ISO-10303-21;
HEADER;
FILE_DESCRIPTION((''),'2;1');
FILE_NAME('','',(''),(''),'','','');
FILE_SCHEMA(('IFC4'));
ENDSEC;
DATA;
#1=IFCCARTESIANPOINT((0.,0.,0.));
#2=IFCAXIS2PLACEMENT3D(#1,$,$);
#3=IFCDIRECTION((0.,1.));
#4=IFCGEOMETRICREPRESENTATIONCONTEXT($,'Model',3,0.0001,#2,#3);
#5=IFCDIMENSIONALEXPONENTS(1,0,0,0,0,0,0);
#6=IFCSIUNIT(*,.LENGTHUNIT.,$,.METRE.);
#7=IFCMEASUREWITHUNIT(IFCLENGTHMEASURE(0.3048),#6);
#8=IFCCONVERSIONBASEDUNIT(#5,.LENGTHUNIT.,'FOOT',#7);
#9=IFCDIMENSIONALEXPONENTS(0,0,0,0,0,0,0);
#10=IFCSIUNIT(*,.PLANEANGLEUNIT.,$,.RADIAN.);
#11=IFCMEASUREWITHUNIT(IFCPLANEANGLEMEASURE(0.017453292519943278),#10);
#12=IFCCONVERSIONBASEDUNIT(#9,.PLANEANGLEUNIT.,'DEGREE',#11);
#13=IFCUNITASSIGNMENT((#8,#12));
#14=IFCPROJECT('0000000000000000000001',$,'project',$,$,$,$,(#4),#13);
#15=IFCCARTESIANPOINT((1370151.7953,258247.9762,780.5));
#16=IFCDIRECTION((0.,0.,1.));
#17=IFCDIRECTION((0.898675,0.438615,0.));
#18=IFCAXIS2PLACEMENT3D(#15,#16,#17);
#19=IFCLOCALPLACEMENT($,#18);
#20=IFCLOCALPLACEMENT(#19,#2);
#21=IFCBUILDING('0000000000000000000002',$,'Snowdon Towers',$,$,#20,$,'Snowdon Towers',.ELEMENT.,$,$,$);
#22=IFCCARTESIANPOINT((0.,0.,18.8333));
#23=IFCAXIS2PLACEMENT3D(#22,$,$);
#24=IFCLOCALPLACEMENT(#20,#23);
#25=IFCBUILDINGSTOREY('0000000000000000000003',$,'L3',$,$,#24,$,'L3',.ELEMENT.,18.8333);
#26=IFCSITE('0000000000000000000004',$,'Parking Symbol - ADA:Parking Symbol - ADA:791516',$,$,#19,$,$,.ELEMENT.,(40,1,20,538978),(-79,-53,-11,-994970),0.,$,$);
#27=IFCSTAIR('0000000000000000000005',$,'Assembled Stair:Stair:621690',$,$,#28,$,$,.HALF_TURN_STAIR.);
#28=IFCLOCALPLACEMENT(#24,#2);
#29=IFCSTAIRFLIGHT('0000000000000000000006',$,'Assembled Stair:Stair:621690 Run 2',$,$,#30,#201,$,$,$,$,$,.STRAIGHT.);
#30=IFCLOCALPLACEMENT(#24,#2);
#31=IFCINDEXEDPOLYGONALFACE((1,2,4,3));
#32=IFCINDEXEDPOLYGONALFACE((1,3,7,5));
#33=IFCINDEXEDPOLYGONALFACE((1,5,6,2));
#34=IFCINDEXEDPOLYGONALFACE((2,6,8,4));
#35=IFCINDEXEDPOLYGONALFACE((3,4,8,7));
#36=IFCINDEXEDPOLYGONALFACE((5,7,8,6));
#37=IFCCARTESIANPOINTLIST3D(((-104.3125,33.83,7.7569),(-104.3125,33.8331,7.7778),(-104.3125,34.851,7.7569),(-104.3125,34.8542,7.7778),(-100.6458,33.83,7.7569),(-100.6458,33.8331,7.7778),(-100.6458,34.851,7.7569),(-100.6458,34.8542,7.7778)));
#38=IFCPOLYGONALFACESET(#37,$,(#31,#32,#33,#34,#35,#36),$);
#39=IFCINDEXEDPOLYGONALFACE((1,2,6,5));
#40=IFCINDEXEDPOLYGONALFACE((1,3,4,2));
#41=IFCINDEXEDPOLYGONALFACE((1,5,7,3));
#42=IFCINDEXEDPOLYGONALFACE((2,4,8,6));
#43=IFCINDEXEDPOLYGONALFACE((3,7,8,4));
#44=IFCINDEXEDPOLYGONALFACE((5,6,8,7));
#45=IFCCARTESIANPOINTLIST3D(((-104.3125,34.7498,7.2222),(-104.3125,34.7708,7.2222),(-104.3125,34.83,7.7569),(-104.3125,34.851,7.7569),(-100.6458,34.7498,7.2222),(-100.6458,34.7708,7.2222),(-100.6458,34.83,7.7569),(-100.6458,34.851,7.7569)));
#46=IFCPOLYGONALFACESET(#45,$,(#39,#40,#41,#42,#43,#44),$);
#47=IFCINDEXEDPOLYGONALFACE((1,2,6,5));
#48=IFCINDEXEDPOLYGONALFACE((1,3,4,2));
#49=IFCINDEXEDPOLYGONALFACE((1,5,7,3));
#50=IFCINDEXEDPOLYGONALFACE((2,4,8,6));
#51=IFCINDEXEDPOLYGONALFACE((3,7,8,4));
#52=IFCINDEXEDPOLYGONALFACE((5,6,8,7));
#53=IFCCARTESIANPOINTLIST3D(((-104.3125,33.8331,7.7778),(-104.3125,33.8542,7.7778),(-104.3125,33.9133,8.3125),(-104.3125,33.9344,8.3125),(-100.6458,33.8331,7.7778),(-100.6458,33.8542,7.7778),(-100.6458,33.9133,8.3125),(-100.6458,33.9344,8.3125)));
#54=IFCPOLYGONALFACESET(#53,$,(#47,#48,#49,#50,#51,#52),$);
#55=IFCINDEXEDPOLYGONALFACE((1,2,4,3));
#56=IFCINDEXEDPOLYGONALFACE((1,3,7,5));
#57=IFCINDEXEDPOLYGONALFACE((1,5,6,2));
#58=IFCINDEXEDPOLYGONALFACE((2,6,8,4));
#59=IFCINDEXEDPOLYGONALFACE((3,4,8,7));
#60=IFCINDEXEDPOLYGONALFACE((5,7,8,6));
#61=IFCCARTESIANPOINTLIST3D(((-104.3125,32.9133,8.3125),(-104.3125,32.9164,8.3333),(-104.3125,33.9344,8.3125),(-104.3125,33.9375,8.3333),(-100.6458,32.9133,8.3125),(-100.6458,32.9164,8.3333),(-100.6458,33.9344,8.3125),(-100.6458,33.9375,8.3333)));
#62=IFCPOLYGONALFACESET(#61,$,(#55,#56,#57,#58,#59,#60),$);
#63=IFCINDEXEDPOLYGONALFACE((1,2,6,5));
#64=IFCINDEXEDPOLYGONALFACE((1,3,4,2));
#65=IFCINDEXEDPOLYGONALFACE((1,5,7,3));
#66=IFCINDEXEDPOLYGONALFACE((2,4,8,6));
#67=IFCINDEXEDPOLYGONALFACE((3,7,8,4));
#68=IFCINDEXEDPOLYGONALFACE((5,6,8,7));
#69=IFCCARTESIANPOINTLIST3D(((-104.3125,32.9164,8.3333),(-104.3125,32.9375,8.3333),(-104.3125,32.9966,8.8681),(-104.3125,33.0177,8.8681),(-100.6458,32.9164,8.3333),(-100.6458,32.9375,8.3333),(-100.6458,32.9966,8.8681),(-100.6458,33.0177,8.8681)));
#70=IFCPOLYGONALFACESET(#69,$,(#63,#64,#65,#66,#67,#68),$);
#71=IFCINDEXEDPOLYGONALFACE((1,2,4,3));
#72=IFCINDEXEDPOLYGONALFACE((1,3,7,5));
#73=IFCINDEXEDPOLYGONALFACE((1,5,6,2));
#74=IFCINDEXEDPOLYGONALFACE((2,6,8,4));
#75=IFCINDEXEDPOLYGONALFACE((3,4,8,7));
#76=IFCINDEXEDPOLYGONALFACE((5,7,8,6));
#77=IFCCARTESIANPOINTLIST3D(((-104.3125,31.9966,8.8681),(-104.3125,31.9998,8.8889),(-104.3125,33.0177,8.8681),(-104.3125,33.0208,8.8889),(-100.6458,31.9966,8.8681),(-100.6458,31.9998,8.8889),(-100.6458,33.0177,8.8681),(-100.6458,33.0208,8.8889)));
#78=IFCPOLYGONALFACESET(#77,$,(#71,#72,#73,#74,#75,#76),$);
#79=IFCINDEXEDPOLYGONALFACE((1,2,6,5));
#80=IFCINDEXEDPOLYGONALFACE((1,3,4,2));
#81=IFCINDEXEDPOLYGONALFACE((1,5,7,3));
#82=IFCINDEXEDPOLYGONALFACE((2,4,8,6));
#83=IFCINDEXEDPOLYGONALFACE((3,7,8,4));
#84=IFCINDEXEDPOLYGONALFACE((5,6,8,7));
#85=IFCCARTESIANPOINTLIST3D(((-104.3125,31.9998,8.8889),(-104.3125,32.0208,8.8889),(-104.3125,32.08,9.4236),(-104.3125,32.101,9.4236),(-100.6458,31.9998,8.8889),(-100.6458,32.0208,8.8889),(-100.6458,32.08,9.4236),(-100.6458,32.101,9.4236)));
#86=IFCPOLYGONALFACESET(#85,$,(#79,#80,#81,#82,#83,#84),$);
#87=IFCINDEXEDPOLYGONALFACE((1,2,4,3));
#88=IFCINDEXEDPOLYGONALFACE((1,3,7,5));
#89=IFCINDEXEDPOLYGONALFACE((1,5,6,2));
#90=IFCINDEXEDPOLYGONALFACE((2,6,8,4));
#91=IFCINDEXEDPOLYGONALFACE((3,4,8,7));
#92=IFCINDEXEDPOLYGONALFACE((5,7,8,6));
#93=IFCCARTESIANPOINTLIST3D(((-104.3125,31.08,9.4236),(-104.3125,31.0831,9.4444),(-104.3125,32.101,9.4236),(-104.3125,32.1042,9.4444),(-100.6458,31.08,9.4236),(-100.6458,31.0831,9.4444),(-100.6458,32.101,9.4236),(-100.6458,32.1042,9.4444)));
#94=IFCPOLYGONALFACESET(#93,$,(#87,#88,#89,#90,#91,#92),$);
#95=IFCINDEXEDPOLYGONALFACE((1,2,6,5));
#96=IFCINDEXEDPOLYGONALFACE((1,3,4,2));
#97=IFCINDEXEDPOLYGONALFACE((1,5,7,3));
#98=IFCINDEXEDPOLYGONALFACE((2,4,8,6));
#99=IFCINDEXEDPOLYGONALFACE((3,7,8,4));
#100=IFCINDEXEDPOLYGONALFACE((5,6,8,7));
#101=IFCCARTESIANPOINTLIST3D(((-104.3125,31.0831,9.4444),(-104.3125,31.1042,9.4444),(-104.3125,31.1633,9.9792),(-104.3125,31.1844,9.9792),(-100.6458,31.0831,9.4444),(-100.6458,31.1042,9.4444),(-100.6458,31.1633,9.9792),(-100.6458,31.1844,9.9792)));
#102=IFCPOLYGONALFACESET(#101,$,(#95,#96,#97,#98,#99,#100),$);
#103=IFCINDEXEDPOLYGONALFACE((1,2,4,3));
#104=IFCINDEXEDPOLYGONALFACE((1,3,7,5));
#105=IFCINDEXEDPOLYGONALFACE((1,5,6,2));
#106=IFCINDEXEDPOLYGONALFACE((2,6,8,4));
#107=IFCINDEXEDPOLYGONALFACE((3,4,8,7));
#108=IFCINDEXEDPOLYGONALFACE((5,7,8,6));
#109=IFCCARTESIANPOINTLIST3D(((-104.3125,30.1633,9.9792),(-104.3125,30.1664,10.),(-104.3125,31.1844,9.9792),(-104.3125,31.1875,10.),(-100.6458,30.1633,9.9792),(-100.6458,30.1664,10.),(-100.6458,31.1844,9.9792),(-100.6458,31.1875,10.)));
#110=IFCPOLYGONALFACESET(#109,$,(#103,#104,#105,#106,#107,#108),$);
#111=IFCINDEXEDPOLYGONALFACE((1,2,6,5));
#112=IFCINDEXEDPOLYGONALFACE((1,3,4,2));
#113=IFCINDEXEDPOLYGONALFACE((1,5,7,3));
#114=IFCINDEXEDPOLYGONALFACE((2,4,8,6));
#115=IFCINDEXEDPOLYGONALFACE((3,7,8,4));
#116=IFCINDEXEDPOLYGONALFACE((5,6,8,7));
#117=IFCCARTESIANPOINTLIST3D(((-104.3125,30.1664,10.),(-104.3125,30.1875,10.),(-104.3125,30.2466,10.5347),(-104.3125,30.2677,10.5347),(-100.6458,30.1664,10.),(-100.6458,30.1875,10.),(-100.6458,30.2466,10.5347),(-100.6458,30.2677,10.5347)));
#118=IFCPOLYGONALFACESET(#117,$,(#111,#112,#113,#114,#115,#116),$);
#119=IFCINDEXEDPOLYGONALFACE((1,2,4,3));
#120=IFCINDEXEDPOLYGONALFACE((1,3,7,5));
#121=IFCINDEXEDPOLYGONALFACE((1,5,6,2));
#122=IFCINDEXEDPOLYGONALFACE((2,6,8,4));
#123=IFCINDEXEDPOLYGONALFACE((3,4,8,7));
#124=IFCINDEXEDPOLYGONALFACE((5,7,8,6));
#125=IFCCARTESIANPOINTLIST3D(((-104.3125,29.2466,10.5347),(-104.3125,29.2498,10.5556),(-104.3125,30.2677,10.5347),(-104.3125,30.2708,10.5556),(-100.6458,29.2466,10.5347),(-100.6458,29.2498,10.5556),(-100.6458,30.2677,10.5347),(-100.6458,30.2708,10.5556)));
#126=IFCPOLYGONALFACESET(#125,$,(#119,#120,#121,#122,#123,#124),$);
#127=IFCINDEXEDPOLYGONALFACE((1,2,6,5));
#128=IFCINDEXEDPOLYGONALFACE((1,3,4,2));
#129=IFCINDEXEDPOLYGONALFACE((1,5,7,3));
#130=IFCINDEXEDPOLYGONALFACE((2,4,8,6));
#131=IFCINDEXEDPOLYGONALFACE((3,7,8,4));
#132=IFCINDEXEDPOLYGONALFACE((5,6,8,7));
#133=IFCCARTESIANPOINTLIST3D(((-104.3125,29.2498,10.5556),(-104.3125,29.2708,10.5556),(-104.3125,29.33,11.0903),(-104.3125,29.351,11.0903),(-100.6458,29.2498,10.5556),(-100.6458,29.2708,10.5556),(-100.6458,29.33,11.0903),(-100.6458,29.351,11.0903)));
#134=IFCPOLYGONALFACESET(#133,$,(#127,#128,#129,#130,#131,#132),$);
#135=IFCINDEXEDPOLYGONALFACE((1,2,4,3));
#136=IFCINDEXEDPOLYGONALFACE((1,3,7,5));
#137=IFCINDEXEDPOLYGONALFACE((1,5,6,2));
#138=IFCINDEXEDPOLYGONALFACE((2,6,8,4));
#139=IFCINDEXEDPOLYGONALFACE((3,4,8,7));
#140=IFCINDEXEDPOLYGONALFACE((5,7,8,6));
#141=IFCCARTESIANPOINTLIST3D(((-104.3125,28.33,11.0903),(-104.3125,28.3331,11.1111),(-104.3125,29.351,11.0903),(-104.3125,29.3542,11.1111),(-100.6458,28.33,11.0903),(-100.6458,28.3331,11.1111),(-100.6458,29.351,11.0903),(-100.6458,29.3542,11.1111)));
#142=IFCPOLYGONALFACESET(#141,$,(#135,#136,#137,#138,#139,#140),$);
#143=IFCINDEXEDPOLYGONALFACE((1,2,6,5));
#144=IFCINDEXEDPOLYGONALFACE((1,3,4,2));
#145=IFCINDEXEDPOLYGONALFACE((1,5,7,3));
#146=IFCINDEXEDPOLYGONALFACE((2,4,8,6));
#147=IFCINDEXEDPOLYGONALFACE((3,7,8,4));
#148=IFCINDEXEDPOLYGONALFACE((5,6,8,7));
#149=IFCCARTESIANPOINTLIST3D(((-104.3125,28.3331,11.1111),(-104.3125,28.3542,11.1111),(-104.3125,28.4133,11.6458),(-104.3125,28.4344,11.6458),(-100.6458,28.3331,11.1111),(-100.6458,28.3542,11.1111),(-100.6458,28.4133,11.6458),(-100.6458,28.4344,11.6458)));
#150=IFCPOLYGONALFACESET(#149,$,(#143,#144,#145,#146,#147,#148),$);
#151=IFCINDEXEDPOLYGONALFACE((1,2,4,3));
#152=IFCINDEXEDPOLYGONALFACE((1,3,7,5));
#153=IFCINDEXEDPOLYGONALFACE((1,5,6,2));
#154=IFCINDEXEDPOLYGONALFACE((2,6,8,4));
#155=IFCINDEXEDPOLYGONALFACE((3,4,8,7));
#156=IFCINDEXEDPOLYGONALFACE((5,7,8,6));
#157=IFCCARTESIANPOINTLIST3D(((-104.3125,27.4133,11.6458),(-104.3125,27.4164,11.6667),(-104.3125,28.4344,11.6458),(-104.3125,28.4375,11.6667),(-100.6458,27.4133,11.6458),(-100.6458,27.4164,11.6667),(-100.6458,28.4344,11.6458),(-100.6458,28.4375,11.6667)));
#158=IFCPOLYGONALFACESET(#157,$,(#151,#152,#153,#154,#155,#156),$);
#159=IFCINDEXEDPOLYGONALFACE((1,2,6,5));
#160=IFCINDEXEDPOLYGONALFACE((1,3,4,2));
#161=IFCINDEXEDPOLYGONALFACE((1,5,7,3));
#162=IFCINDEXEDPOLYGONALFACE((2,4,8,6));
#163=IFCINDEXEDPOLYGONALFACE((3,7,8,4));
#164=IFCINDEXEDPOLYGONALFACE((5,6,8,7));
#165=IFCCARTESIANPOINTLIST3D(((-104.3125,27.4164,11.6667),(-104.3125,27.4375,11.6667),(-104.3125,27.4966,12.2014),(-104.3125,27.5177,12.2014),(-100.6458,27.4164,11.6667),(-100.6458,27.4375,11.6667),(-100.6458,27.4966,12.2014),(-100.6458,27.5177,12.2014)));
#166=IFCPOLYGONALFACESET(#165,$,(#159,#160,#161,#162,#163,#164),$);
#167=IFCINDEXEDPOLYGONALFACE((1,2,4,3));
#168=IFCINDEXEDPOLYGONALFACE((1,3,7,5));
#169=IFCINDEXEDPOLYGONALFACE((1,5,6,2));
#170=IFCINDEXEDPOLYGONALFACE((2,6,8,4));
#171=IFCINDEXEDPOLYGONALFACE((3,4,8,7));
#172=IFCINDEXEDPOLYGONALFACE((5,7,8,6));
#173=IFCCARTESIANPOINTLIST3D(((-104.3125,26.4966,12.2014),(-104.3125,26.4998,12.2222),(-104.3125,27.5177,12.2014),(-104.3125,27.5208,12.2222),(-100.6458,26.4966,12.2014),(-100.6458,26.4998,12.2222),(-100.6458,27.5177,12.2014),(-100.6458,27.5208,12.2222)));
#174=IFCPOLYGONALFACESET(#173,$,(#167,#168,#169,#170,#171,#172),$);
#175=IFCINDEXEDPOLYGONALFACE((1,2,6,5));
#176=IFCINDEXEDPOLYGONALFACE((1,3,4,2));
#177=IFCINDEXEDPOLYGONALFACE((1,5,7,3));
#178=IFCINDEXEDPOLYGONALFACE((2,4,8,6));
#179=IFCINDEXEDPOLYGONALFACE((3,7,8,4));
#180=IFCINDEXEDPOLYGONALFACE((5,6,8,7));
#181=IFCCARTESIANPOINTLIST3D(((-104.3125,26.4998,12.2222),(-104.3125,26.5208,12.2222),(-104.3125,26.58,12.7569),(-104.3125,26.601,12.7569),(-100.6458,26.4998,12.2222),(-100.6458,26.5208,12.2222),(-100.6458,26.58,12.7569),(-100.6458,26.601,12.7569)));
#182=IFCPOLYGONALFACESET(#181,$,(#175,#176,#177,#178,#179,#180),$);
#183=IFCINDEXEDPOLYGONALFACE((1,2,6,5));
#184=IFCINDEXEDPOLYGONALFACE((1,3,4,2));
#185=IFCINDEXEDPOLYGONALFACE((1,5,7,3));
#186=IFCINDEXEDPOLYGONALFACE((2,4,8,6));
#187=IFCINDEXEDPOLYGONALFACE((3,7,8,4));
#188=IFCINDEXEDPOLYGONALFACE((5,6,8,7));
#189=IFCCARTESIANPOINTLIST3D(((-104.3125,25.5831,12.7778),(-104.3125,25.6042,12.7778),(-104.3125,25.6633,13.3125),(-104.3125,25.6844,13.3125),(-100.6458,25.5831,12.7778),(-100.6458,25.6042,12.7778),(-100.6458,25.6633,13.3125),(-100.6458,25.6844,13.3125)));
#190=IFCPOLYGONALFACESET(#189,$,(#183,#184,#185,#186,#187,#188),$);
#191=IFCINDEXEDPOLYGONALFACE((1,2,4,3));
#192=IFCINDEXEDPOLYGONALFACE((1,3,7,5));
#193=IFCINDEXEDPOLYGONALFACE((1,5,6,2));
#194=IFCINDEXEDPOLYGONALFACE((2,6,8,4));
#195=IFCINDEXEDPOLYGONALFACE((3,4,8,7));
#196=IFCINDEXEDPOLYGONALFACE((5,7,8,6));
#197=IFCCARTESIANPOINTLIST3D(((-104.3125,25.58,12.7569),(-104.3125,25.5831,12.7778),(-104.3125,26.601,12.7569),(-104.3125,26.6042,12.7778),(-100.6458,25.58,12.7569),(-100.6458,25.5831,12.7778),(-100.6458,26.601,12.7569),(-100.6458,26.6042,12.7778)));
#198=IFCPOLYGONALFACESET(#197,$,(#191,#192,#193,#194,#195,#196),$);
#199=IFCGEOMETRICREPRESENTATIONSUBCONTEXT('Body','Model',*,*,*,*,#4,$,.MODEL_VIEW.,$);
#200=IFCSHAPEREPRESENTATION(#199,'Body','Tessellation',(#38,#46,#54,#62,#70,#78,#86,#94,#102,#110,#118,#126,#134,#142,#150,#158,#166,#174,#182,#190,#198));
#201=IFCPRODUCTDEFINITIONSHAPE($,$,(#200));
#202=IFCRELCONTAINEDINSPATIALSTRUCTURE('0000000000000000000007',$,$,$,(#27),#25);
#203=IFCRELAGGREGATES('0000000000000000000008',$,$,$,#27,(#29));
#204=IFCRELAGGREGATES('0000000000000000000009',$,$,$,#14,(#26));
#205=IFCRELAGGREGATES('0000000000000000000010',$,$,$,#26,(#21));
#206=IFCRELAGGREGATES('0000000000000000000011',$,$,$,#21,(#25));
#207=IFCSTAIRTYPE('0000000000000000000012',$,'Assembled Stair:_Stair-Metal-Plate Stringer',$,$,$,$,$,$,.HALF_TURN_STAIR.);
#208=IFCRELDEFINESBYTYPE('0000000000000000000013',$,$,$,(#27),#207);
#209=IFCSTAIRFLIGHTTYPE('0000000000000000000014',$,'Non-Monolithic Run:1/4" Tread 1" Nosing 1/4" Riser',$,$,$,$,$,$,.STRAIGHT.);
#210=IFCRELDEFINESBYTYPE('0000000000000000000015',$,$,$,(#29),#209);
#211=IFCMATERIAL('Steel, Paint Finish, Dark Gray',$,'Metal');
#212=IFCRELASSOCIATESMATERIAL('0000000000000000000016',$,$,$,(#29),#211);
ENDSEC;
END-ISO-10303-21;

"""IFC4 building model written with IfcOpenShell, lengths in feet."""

from ifc_helpers import new_model, entity, si_unit, converted_unit, direction, frame, origin, place, context, subcontext, project, spatial, indexed_curve, outline, extrude, material, type_object, element, aggregate, save


model = new_model("IFC4")

# Units and contexts
model_context = context("Model", 3, precision=0.0001, world=origin(), true_north=direction((0.0, 1.0)))
body_context = subcontext(model_context, "Body", "Model", "MODEL_VIEW")
ifc_project = project(units=[converted_unit("LENGTHUNIT", "FOOT", entity("IfcLengthMeasure", 0.3048), si_unit("LENGTHUNIT", "METRE"), dimensions=[1, 0, 0, 0, 0, 0, 0]), converted_unit("PLANEANGLEUNIT", "DEGREE", entity("IfcPlaneAngleMeasure", 0.017453292519943278), si_unit("PLANEANGLEUNIT", "RADIAN"), dimensions=[0, 0, 0, 0, 0, 0, 0])], contexts=[model_context])

# Site, building, storey
site_placement = place(None, frame((1370151.7953, 258247.9762, 780.5), z_axis=(0.0, 0.0, 1.0), x_axis=(0.898675, 0.438615, 0.0)))
site = spatial("IfcSite", under=ifc_project, at=site_placement, Name="Parking Symbol - ADA:Parking Symbol - ADA:791516", CompositionType="ELEMENT", RefLatitude=(40, 1, 20, 538978), RefLongitude=(-79, -53, -11, -994970), RefElevation=0.0)
building_placement = place(site_placement, origin())
building = spatial("IfcBuilding", under=site, at=building_placement, Name="Snowdon Towers", LongName="Snowdon Towers", CompositionType="ELEMENT")
storey_placement = place(building_placement, frame((0.0, 0.0, 18.8333)))
storey = spatial("IfcBuildingStorey", under=building, at=storey_placement, Name="L3", LongName="L3", CompositionType="ELEMENT", Elevation=18.8333)

# Stair
stair_type = type_object("IfcStairType", Name="Assembled Stair:_Stair-Metal-Plate Stringer", PredefinedType="HALF_TURN_STAIR")
stair_1_placement = place(storey_placement, origin())
stair_1 = element("IfcStair", 1, at=stair_1_placement, inside=storey, type_object=stair_type, Name="Assembled Stair:Stair:621690", PredefinedType="HALF_TURN_STAIR")
ifc_material_1 = material(Name="Steel, Paint Finish, Dark Gray", Category="Metal")

# Stair flight
stair_flight_type = type_object("IfcStairFlightType", Name="Non-Monolithic Run:1/4\" Tread 1\" Nosing 1/4\" Riser", PredefinedType="STRAIGHT")
stair_flight_1_placement = place(stair_1_placement, origin())
stair_flight_1 = element("IfcStairFlight", 2, at=stair_flight_1_placement, type_object=stair_flight_type, material=ifc_material_1, Name="Assembled Stair:Stair:621690 Run 2", PredefinedType="STRAIGHT", context=body_context, shape_type="SweptSolid", body=[
    extrude(outline(indexed_curve([(0.0652, -0.5049), (0.0863, -0.5049), (-0.0652, 0.5049), (-0.0863, 0.5049), (0.0652, -0.5049)], self_intersect=False)), frame((-104.3125, 34.3421, 7.7674), z_axis=(1.0, 0.0, 0.0), x_axis=(0.0, -0.14834, -0.988936)), (0.0, 0.0, 1.0), 3.6667),
    extrude(outline(indexed_curve([(-0.0506, -0.2674), (-0.0296, -0.2674), (0.0506, 0.2674), (0.0296, 0.2674), (-0.0506, -0.2674)], self_intersect=False)), frame((-104.3125, 34.8004, 7.4896), z_axis=(1.0, 0.0, 0.0), x_axis=(0.0, -1.0, 0.0)), (0.0, 0.0, 1.0), 3.6667),
    extrude(outline(indexed_curve([(-0.0506, -0.2674), (-0.0296, -0.2674), (0.0506, 0.2674), (0.0296, 0.2674), (-0.0506, -0.2674)], self_intersect=False)), frame((-104.3125, 33.8837, 8.0451), z_axis=(1.0, 0.0, 0.0), x_axis=(0.0, -1.0, 0.0)), (0.0, 0.0, 1.0), 3.6667),
    extrude(outline(indexed_curve([(0.0652, -0.5049), (0.0863, -0.5049), (-0.0652, 0.5049), (-0.0863, 0.5049), (0.0652, -0.5049)], self_intersect=False)), frame((-104.3125, 33.4254, 8.3229), z_axis=(1.0, 0.0, 0.0), x_axis=(0.0, -0.14834, -0.988936)), (0.0, 0.0, 1.0), 3.6667),
    extrude(outline(indexed_curve([(-0.0506, -0.2674), (-0.0296, -0.2674), (0.0506, 0.2674), (0.0296, 0.2674), (-0.0506, -0.2674)], self_intersect=False)), frame((-104.3125, 32.9671, 8.6007), z_axis=(1.0, 0.0, 0.0), x_axis=(0.0, -1.0, 0.0)), (0.0, 0.0, 1.0), 3.6667),
    extrude(outline(indexed_curve([(0.0652, -0.5049), (0.0863, -0.5049), (-0.0652, 0.5049), (-0.0863, 0.5049), (0.0652, -0.5049)], self_intersect=False)), frame((-104.3125, 32.5087, 8.8785), z_axis=(1.0, 0.0, 0.0), x_axis=(0.0, -0.14834, -0.988936)), (0.0, 0.0, 1.0), 3.6667),
    extrude(outline(indexed_curve([(-0.0506, -0.2674), (-0.0296, -0.2674), (0.0506, 0.2674), (0.0296, 0.2674), (-0.0506, -0.2674)], self_intersect=False)), frame((-104.3125, 32.0504, 9.1562), z_axis=(1.0, 0.0, 0.0), x_axis=(0.0, -1.0, 0.0)), (0.0, 0.0, 1.0), 3.6667),
    extrude(outline(indexed_curve([(0.0652, -0.5049), (0.0863, -0.5049), (-0.0652, 0.5049), (-0.0863, 0.5049), (0.0652, -0.5049)], self_intersect=False)), frame((-104.3125, 31.5921, 9.434), z_axis=(1.0, 0.0, 0.0), x_axis=(0.0, -0.14834, -0.988936)), (0.0, 0.0, 1.0), 3.6667),
    extrude(outline(indexed_curve([(-0.0506, -0.2674), (-0.0296, -0.2674), (0.0506, 0.2674), (0.0296, 0.2674), (-0.0506, -0.2674)], self_intersect=False)), frame((-104.3125, 31.1337, 9.7118), z_axis=(1.0, 0.0, 0.0), x_axis=(0.0, -1.0, 0.0)), (0.0, 0.0, 1.0), 3.6667),
    extrude(outline(indexed_curve([(0.0652, -0.5049), (0.0863, -0.5049), (-0.0652, 0.5049), (-0.0863, 0.5049), (0.0652, -0.5049)], self_intersect=False)), frame((-104.3125, 30.6754, 9.9896), z_axis=(1.0, 0.0, 0.0), x_axis=(0.0, -0.14834, -0.988936)), (0.0, 0.0, 1.0), 3.6667),
    extrude(outline(indexed_curve([(-0.0506, -0.2674), (-0.0296, -0.2674), (0.0506, 0.2674), (0.0296, 0.2674), (-0.0506, -0.2674)], self_intersect=False)), frame((-104.3125, 30.2171, 10.2674), z_axis=(1.0, 0.0, 0.0), x_axis=(0.0, -1.0, 0.0)), (0.0, 0.0, 1.0), 3.6667),
    extrude(outline(indexed_curve([(0.0652, -0.5049), (0.0863, -0.5049), (-0.0652, 0.5049), (-0.0863, 0.5049), (0.0652, -0.5049)], self_intersect=False)), frame((-104.3125, 29.7587, 10.5451), z_axis=(1.0, 0.0, 0.0), x_axis=(0.0, -0.14834, -0.988936)), (0.0, 0.0, 1.0), 3.6667),
    extrude(outline(indexed_curve([(-0.0506, -0.2674), (-0.0296, -0.2674), (0.0506, 0.2674), (0.0296, 0.2674), (-0.0506, -0.2674)], self_intersect=False)), frame((-104.3125, 29.3004, 10.8229), z_axis=(1.0, 0.0, 0.0), x_axis=(0.0, -1.0, 0.0)), (0.0, 0.0, 1.0), 3.6667),
    extrude(outline(indexed_curve([(0.0652, -0.5049), (0.0863, -0.5049), (-0.0652, 0.5049), (-0.0863, 0.5049), (0.0652, -0.5049)], self_intersect=False)), frame((-104.3125, 28.8421, 11.1007), z_axis=(1.0, 0.0, 0.0), x_axis=(0.0, -0.14834, -0.988936)), (0.0, 0.0, 1.0), 3.6667),
    extrude(outline(indexed_curve([(-0.0506, -0.2674), (-0.0296, -0.2674), (0.0506, 0.2674), (0.0296, 0.2674), (-0.0506, -0.2674)], self_intersect=False)), frame((-104.3125, 28.3837, 11.3785), z_axis=(1.0, 0.0, 0.0), x_axis=(0.0, -1.0, 0.0)), (0.0, 0.0, 1.0), 3.6667),
    extrude(outline(indexed_curve([(0.0652, -0.5049), (0.0863, -0.5049), (-0.0652, 0.5049), (-0.0863, 0.5049), (0.0652, -0.5049)], self_intersect=False)), frame((-104.3125, 27.9254, 11.6563), z_axis=(1.0, 0.0, 0.0), x_axis=(0.0, -0.14834, -0.988936)), (0.0, 0.0, 1.0), 3.6667),
    extrude(outline(indexed_curve([(-0.0506, -0.2674), (-0.0296, -0.2674), (0.0506, 0.2674), (0.0296, 0.2674), (-0.0506, -0.2674)], self_intersect=False)), frame((-104.3125, 27.4671, 11.934), z_axis=(1.0, 0.0, 0.0), x_axis=(0.0, -1.0, 0.0)), (0.0, 0.0, 1.0), 3.6667),
    extrude(outline(indexed_curve([(0.0652, -0.5049), (0.0863, -0.5049), (-0.0652, 0.5049), (-0.0863, 0.5049), (0.0652, -0.5049)], self_intersect=False)), frame((-104.3125, 27.0087, 12.2118), z_axis=(1.0, 0.0, 0.0), x_axis=(0.0, -0.14834, -0.988936)), (0.0, 0.0, 1.0), 3.6667),
    extrude(outline(indexed_curve([(-0.0506, -0.2674), (-0.0296, -0.2674), (0.0506, 0.2674), (0.0296, 0.2674), (-0.0506, -0.2674)], self_intersect=False)), frame((-104.3125, 26.5504, 12.4896), z_axis=(1.0, 0.0, 0.0), x_axis=(0.0, -1.0, 0.0)), (0.0, 0.0, 1.0), 3.6667),
    extrude(outline(indexed_curve([(-0.0506, -0.2674), (-0.0296, -0.2674), (0.0506, 0.2674), (0.0296, 0.2674), (-0.0506, -0.2674)], self_intersect=False)), frame((-104.3125, 25.6337, 13.0451), z_axis=(1.0, 0.0, 0.0), x_axis=(0.0, -1.0, 0.0)), (0.0, 0.0, 1.0), 3.6667),
    extrude(outline(indexed_curve([(0.0652, -0.5049), (0.0863, -0.5049), (-0.0652, 0.5049), (-0.0863, 0.5049), (0.0652, -0.5049)], self_intersect=False)), frame((-104.3125, 26.0921, 12.7674), z_axis=(1.0, 0.0, 0.0), x_axis=(0.0, -0.14834, -0.988936)), (0.0, 0.0, 1.0), 3.6667),
])
aggregate(stair_1, [stair_flight_1])

save(model, "model.ifc")
